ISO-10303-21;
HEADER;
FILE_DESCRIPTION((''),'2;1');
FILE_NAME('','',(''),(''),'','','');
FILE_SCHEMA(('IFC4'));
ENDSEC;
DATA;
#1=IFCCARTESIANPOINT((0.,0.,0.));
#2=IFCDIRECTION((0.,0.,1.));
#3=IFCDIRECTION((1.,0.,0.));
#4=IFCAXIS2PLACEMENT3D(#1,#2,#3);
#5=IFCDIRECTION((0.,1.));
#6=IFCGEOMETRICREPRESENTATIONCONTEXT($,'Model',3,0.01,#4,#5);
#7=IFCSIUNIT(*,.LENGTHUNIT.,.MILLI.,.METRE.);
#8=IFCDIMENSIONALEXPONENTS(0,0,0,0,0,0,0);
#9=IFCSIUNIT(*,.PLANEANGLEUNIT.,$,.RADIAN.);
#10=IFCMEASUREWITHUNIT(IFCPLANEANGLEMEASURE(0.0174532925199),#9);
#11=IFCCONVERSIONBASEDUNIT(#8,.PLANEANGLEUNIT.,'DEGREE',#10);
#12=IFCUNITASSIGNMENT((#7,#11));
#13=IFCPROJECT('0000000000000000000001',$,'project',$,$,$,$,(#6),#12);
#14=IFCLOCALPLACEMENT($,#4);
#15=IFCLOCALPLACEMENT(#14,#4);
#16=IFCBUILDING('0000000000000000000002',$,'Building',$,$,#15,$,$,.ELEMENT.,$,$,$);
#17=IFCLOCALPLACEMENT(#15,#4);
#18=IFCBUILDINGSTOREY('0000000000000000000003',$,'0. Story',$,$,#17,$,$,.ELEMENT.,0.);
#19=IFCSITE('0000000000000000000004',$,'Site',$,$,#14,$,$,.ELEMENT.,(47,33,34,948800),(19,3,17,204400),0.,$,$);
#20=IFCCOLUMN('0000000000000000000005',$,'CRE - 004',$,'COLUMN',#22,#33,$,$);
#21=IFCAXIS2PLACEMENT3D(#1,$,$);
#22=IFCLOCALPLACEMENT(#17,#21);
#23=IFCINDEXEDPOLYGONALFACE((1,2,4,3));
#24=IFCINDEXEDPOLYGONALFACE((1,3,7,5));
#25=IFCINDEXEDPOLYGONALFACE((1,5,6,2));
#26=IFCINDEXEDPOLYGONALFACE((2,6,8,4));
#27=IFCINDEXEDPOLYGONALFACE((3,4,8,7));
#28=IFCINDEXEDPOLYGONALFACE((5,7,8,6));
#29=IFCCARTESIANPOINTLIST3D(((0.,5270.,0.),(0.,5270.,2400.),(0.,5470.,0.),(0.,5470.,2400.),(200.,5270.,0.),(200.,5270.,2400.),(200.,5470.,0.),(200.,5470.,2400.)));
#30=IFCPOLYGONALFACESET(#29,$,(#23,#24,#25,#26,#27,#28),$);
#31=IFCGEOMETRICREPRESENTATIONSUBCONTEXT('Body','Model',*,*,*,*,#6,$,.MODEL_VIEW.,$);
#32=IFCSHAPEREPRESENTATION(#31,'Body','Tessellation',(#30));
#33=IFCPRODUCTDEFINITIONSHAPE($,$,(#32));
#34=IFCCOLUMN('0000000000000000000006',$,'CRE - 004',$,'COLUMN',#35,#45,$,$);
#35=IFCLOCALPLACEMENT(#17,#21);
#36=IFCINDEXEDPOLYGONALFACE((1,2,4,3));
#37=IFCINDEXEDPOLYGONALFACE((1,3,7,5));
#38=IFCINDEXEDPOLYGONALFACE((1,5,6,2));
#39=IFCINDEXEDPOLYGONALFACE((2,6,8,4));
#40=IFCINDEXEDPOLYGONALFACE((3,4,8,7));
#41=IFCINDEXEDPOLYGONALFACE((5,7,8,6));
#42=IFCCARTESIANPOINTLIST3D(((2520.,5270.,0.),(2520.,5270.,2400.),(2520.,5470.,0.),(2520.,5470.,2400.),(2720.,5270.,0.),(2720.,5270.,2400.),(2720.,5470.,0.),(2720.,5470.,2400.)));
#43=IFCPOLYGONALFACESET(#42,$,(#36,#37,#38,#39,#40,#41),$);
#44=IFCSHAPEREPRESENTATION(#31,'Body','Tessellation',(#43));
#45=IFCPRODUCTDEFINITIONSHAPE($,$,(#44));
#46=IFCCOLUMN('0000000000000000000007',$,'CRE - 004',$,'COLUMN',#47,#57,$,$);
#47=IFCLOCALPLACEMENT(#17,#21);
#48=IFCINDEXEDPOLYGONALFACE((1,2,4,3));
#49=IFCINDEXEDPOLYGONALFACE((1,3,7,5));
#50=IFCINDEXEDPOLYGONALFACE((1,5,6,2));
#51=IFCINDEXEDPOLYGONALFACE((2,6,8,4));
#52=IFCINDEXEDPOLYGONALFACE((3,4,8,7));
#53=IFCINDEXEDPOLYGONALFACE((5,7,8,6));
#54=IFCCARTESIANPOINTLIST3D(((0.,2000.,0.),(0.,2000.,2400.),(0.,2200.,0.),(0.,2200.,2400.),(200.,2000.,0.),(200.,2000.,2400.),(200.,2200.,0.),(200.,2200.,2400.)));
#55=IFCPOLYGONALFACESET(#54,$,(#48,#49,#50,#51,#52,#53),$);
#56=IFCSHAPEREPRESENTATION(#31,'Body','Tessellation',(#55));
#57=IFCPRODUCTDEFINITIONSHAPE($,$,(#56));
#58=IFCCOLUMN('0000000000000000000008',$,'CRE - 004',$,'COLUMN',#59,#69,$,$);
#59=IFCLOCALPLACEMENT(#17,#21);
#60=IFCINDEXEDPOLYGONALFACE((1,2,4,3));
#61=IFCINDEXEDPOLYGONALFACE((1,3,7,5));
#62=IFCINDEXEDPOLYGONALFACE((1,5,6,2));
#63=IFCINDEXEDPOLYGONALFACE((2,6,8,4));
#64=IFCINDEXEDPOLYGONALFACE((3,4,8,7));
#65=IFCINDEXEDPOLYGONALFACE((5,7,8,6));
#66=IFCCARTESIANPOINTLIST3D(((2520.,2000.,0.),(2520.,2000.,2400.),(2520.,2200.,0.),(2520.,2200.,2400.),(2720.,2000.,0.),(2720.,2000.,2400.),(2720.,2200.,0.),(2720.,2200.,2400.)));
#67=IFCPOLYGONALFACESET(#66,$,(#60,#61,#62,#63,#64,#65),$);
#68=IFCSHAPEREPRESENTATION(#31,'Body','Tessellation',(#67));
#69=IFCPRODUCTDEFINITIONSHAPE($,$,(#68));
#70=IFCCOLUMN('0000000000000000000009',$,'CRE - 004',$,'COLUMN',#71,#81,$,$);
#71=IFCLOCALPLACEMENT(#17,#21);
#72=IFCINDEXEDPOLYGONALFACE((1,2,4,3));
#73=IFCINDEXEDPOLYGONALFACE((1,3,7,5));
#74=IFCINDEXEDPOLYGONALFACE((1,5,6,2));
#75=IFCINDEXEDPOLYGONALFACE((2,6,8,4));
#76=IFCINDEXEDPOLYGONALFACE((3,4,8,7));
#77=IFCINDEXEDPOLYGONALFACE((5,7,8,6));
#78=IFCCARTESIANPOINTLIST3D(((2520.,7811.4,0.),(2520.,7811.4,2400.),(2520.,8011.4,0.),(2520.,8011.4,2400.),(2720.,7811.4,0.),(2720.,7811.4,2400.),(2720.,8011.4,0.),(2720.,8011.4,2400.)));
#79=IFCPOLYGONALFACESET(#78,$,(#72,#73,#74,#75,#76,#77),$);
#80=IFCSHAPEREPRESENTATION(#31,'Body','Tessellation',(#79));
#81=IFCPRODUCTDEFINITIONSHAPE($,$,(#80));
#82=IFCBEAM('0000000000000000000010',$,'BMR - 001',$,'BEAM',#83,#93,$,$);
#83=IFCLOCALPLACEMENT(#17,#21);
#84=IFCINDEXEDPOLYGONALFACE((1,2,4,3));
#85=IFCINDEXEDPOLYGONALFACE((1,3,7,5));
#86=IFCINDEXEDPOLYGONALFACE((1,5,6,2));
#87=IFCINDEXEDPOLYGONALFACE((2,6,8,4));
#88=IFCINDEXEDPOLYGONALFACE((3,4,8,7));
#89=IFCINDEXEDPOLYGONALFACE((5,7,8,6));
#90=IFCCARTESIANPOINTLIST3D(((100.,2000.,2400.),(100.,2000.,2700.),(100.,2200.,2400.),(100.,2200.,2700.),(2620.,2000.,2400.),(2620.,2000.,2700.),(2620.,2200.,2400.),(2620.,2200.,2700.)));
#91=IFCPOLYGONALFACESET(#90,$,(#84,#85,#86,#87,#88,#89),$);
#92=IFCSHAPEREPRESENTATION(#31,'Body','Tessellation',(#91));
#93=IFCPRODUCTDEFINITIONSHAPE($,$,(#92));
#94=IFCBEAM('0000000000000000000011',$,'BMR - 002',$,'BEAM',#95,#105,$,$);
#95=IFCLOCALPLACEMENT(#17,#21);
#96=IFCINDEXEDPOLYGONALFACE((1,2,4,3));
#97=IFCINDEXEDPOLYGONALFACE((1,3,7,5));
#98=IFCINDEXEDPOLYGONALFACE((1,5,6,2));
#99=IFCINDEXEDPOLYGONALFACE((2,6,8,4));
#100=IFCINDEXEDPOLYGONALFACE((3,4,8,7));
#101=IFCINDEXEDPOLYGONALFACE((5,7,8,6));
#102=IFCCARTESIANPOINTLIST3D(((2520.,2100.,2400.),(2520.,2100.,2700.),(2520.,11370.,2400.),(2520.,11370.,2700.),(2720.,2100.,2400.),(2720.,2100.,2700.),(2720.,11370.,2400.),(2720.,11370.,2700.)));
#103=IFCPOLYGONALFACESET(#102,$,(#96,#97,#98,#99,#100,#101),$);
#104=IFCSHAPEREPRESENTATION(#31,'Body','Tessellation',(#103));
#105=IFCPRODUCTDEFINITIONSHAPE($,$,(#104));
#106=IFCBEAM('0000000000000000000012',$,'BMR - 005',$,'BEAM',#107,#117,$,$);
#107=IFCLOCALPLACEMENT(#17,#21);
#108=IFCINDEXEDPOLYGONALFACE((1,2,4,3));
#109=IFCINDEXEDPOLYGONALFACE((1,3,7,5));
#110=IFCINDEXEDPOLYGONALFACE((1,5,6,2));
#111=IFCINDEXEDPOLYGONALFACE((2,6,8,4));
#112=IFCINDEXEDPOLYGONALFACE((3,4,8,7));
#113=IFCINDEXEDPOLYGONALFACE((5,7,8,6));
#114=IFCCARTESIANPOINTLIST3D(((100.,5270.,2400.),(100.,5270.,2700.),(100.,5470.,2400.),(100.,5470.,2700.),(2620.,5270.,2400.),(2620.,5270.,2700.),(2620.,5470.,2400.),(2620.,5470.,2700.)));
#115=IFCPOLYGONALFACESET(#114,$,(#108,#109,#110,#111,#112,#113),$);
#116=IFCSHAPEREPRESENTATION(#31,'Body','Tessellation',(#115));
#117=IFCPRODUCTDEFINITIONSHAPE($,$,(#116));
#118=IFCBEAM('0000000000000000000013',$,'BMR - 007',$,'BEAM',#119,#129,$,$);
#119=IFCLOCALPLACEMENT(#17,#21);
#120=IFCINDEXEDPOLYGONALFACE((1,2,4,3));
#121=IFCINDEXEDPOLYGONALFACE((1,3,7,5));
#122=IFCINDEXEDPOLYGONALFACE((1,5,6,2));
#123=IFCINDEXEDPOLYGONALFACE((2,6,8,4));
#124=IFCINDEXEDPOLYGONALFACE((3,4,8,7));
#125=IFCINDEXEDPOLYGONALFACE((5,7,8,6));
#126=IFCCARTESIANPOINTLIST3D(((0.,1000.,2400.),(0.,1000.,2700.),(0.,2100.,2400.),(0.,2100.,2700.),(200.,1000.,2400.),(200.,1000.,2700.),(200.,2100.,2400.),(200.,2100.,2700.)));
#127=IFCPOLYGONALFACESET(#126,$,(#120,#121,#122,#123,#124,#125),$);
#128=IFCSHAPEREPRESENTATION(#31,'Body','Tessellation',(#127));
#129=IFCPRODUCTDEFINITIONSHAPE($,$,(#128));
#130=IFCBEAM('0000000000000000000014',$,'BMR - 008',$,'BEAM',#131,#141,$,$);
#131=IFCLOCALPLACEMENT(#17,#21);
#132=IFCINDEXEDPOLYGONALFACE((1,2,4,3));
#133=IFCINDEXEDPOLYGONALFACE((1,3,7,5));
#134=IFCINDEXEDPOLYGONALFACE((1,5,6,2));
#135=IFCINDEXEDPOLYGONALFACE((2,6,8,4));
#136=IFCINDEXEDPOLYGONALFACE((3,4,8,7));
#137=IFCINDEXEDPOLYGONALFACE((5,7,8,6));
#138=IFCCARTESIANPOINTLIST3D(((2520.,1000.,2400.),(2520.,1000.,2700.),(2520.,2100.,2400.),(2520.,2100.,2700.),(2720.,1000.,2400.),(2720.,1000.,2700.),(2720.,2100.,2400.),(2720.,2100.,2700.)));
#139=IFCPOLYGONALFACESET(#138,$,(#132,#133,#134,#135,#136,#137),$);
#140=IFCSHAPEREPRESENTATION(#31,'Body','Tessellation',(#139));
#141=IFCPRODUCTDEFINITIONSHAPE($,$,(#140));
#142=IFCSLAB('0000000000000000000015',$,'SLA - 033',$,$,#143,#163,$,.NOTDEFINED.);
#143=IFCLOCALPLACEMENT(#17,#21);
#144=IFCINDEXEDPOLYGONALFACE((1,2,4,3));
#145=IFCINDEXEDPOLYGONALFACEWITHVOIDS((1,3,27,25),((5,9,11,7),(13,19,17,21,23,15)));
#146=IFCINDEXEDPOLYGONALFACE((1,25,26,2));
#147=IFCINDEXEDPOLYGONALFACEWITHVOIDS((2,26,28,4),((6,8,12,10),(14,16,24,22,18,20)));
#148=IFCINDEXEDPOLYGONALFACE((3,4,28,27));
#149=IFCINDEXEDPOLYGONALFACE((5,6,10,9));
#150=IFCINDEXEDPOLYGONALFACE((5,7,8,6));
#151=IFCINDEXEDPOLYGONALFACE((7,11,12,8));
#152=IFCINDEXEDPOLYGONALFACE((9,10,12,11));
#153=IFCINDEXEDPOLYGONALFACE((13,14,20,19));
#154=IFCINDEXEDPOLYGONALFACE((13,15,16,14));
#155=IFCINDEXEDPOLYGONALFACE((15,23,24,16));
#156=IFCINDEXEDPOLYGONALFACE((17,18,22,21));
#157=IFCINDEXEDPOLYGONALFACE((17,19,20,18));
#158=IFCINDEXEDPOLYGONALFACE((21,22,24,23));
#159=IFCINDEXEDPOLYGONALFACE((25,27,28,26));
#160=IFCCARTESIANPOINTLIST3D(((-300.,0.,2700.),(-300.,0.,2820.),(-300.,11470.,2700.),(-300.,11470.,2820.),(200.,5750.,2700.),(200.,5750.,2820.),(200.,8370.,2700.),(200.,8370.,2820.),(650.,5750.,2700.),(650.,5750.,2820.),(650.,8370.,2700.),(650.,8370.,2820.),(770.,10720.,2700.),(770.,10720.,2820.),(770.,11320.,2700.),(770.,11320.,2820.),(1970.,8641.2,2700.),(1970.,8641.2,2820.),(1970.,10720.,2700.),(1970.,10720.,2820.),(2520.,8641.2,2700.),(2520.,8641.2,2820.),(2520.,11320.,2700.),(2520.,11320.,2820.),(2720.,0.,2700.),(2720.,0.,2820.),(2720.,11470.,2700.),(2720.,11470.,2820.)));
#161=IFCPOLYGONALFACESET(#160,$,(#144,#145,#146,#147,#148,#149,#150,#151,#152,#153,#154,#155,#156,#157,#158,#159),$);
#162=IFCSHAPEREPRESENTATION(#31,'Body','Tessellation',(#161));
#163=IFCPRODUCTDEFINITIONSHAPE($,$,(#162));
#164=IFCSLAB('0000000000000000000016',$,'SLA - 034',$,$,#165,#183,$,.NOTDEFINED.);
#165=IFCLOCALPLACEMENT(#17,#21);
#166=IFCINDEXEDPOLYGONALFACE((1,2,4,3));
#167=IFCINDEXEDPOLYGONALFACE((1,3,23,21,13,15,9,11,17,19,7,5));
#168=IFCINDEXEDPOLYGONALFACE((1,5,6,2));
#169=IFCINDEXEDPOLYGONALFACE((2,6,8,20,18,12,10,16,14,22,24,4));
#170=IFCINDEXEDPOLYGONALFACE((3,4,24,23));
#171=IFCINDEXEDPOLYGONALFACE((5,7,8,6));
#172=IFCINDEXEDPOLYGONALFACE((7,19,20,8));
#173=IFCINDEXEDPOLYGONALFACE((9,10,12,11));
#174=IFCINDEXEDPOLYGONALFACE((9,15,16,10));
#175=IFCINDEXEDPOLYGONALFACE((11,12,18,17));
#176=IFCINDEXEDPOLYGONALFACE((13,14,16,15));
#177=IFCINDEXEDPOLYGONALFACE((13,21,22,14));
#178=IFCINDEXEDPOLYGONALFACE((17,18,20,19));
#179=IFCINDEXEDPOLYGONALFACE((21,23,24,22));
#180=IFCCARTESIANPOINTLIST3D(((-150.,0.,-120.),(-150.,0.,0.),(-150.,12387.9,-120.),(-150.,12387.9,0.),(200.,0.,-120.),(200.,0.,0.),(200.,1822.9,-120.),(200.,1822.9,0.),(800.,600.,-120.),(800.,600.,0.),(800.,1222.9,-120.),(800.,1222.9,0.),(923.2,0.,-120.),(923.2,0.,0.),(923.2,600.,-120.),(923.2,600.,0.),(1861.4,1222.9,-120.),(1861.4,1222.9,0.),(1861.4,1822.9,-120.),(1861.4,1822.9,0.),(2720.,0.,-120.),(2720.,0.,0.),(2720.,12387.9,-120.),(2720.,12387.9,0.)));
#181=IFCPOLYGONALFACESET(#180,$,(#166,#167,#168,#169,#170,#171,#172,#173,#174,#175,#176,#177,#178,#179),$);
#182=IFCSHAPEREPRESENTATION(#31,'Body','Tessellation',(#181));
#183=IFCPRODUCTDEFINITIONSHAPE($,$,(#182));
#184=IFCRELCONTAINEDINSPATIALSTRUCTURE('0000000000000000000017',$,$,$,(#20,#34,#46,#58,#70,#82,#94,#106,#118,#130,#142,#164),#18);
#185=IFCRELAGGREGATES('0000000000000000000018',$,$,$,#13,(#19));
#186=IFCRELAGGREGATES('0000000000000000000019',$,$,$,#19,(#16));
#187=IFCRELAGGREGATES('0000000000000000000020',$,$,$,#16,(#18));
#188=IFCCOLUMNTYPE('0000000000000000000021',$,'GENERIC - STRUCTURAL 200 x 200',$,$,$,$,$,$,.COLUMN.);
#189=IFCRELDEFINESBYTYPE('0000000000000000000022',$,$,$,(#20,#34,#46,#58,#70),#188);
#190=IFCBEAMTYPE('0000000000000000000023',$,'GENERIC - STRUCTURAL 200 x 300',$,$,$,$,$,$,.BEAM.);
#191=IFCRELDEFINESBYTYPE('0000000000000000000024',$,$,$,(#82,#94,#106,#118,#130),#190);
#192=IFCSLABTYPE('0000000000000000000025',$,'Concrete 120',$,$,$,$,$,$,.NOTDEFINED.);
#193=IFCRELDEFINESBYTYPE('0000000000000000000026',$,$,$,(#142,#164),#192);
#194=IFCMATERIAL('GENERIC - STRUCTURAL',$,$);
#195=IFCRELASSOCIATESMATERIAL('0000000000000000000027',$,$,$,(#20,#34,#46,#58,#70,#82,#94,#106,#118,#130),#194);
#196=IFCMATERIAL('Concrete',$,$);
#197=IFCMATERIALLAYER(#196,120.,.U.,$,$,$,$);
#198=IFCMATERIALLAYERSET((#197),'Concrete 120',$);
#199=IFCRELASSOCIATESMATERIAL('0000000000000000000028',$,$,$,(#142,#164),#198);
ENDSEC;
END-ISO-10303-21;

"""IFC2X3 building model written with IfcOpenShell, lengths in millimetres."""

from ifc_helpers import new_model, entity, si_unit, converted_unit, direction, frame, frame_2d, origin_with_axes, origin_2d_with_axis, place, context, subcontext, project, spatial, polyline, rectangle, outline, extrude, material, layer, layer_set, layer_usage, type_object, element, save


model = new_model("IFC2X3")

# Units and contexts
model_context = context("Model", 3, precision=0.01, world=origin_with_axes(), true_north=direction((0.0, 1.0)))
body_context = subcontext(model_context, "Body", "Model", "MODEL_VIEW")
ifc_project = project(units=[si_unit("LENGTHUNIT", "METRE", prefix="MILLI"), converted_unit("PLANEANGLEUNIT", "DEGREE", entity("IfcPlaneAngleMeasure", 0.0174532925199), si_unit("PLANEANGLEUNIT", "RADIAN"), dimensions=[0, 0, 0, 0, 0, 0, 0])], contexts=[model_context])

# Site, building, storey
site_placement = place(None, origin_with_axes())
site = spatial("IfcSite", under=ifc_project, at=site_placement, Name="Site", CompositionType="ELEMENT", RefLatitude=(47, 33, 34, 948800), RefLongitude=(19, 3, 17, 204400), RefElevation=0.0)
building_placement = place(site_placement, origin_with_axes())
building = spatial("IfcBuilding", under=site, at=building_placement, Name="Building", CompositionType="ELEMENT")
storey_placement = place(building_placement, origin_with_axes())
storey = spatial("IfcBuildingStorey", under=building, at=storey_placement, Name="0. Story", CompositionType="ELEMENT", Elevation=0.0)

# Columns
ifc_material_1 = material(Name="GENERIC - STRUCTURAL")
column_type = type_object("IfcColumnType", Name="GENERIC - STRUCTURAL 200 x 200", PredefinedType="COLUMN")
for number, where, z_axis, x_axis, name in (
    (1, (100.0, 5370.0, 0.0), (0.0, 0.0, 1.0), (1.0, 0.0, 0.0), "CRE - 004"),
    (2, (2620.0, 5370.0, 0.0), (0.0, 0.0, 1.0), (1.0, 0.0, 0.0), "CRE - 004"),
    (3, (100.0, 2100.0, 0.0), (0.0, 0.0, 1.0), (1.0, 0.0, 0.0), "CRE - 004"),
    (4, (2620.0, 2100.0, 0.0), (0.0, 0.0, 1.0), (1.0, 0.0, 0.0), "CRE - 004"),
    (5, (2620.0, 7911.4, 0.0), (0.0, 0.0, 1.0), (1.0, 0.0, 0.0), "CRE - 004"),
):
    element("IfcColumn", number, at=place(storey_placement, frame(where, z_axis=z_axis, x_axis=x_axis)), inside=storey, type_object=column_type, material=ifc_material_1, Name=name, ObjectType="COLUMN", context=body_context, shape_type="SweptSolid", body=[
        extrude(rectangle(XDim=200.0, YDim=200.0, at=origin_2d_with_axis()), origin_with_axes(), (0.0, 0.0, 1.0), 2400.0),
    ])

# Beams
beam_type = type_object("IfcBeamType", Name="GENERIC - STRUCTURAL 200 x 300", PredefinedType="BEAM")
beam_1_placement = place(storey_placement, frame((100.0, 2100.0, 2700.0), z_axis=(0.0, 0.0, 1.0), x_axis=(0.0, -1.0, 0.0)))
element("IfcBeam", 6, at=beam_1_placement, inside=storey, type_object=beam_type, material=ifc_material_1, Name="BMR - 001", ObjectType="BEAM", context=body_context, shape_type="SweptSolid", body=[
    extrude(rectangle(XDim=300.0, YDim=200.0, at=frame_2d((-150.0, 0.0), x_axis=(1.0, 0.0))), frame((0.0, 0.0, 0.0), z_axis=(0.0, 1.0, 0.0), x_axis=(0.0, 0.0, 1.0)), (0.0, 0.0, 1.0), 2520.0),
])
beam_2_placement = place(storey_placement, frame((2620.0, 2100.0, 2700.0), z_axis=(0.0, 0.0, 1.0), x_axis=(1.0, 0.0, 0.0)))
element("IfcBeam", 7, at=beam_2_placement, inside=storey, type_object=beam_type, material=ifc_material_1, Name="BMR - 002", ObjectType="BEAM", context=body_context, shape_type="SweptSolid", body=[
    extrude(rectangle(XDim=300.0, YDim=200.0, at=frame_2d((-150.0, 0.0), x_axis=(1.0, 0.0))), frame((0.0, 0.0, 0.0), z_axis=(0.0, 1.0, 0.0), x_axis=(0.0, 0.0, 1.0)), (0.0, 0.0, 1.0), 9270.0),
])
beam_3_placement = place(storey_placement, frame((100.0, 5370.0, 2700.0), z_axis=(0.0, 0.0, 1.0), x_axis=(0.0, -1.0, 0.0)))
element("IfcBeam", 8, at=beam_3_placement, inside=storey, type_object=beam_type, material=ifc_material_1, Name="BMR - 005", ObjectType="BEAM", context=body_context, shape_type="SweptSolid", body=[
    extrude(rectangle(XDim=300.0, YDim=200.0, at=frame_2d((-150.0, 0.0), x_axis=(1.0, 0.0))), frame((0.0, 0.0, 0.0), z_axis=(0.0, 1.0, 0.0), x_axis=(0.0, 0.0, 1.0)), (0.0, 0.0, 1.0), 2520.0),
])
for number, where, z_axis, x_axis, name in (
    (9, (100.0, 2100.0, 2700.0), (0.0, 0.0, 1.0), (-1.0, 0.0, 0.0), "BMR - 007"),
    (10, (2620.0, 2100.0, 2700.0), (0.0, 0.0, 1.0), (-1.0, 0.0, 0.0), "BMR - 008"),
):
    element("IfcBeam", number, at=place(storey_placement, frame(where, z_axis=z_axis, x_axis=x_axis)), inside=storey, type_object=beam_type, material=ifc_material_1, Name=name, ObjectType="BEAM", context=body_context, shape_type="SweptSolid", body=[
        extrude(rectangle(XDim=300.0, YDim=200.0, at=frame_2d((-150.0, 0.0), x_axis=(1.0, 0.0))), frame((0.0, 0.0, 0.0), z_axis=(0.0, 1.0, 0.0), x_axis=(0.0, 0.0, 1.0)), (0.0, 0.0, 1.0), 1100.0),
    ])

# Slab, openings
ifc_material_2 = material(Name="Concrete")
ifc_layer_1 = layer(ifc_material_2, 120.0, ventilated="UNKNOWN")
ifc_layer_set_1 = layer_set([ifc_layer_1], Name="Concrete 120")
ifc_layer_usage_1 = layer_usage(ifc_layer_set_1, "AXIS3", "NEGATIVE", 120.0)
slab_type_1 = type_object("IfcSlabType", Name="Concrete 120", PredefinedType="NOTDEFINED")
slab_1_placement = place(storey_placement, frame((-300.0, 0.0, 2700.0), z_axis=(0.0, 0.0, 1.0), x_axis=(1.0, 0.0, 0.0)))
slab_1 = element("IfcSlab", 11, at=slab_1_placement, inside=storey, type_object=slab_type_1, material=ifc_layer_usage_1, Name="SLA - 033", PredefinedType="NOTDEFINED", context=body_context, shape_type="SweptSolid", body=[
    extrude(outline(polyline([(0.0, 0.0), (3020.0, 0.0), (3020.0, 11470.0), (0.0, 11470.0), (0.0, 0.0)])), origin_with_axes(), (0.0, 0.0, 1.0), 120.0),
])
opening_1_placement = place(slab_1_placement, frame((500.0, 5750.0, 0.0), z_axis=(0.0, 0.0, 1.0), x_axis=(1.0, 0.0, 0.0)))
element("IfcOpeningElement", 12, at=opening_1_placement, cuts=slab_1, context=body_context, shape_type="SweptSolid", body=[
    extrude(outline(polyline([(0.0, 0.0), (450.0, 0.0), (450.0, 2620.0), (0.0, 2620.0), (0.0, 0.0)])), origin_with_axes(), (0.0, 0.0, 1.0), 120.0),
])
opening_2_placement = place(slab_1_placement, frame((1070.0, 10720.0, 0.0), z_axis=(0.0, 0.0, 1.0), x_axis=(1.0, 0.0, 0.0)))
element("IfcOpeningElement", 13, at=opening_2_placement, cuts=slab_1, context=body_context, shape_type="SweptSolid", body=[
    extrude(outline(polyline([(0.0, 0.0), (1200.0, 0.0), (1200.0, -2078.8), (1750.0, -2078.8), (1750.0, 600.0), (0.0, 600.0), (0.0, 0.0)])), origin_with_axes(), (0.0, 0.0, 1.0), 120.0),
])

# Slab
ifc_layer_usage_2 = layer_usage(ifc_layer_set_1, "AXIS3", "NEGATIVE", 120.0)
slab_2_placement = place(storey_placement, frame((2720.0, 0.0, 0.0), z_axis=(0.0, 0.0, 1.0), x_axis=(1.0, 0.0, 0.0)))
element("IfcSlab", 14, at=slab_2_placement, inside=storey, type_object=slab_type_1, material=ifc_layer_usage_2, Name="SLA - 034", PredefinedType="NOTDEFINED", context=body_context, shape_type="SweptSolid", body=[
    extrude(outline(polyline([(0.0, 0.0), (0.0, 12387.9), (-2870.0, 12387.9), (-2870.0, 0.0), (-2520.0, 0.0), (-2520.0, 1822.9), (-858.6, 1822.9), (-858.6, 1222.9), (-1920.0, 1222.9), (-1920.0, 600.0), (-1796.8, 600.0), (-1796.8, 0.0), (0.0, 0.0)])), frame((0.0, 0.0, -120.0), z_axis=(0.0, 0.0, 1.0), x_axis=(1.0, 0.0, 0.0)), (0.0, 0.0, 1.0), 120.0),
])

save(model, "model.ifc")
